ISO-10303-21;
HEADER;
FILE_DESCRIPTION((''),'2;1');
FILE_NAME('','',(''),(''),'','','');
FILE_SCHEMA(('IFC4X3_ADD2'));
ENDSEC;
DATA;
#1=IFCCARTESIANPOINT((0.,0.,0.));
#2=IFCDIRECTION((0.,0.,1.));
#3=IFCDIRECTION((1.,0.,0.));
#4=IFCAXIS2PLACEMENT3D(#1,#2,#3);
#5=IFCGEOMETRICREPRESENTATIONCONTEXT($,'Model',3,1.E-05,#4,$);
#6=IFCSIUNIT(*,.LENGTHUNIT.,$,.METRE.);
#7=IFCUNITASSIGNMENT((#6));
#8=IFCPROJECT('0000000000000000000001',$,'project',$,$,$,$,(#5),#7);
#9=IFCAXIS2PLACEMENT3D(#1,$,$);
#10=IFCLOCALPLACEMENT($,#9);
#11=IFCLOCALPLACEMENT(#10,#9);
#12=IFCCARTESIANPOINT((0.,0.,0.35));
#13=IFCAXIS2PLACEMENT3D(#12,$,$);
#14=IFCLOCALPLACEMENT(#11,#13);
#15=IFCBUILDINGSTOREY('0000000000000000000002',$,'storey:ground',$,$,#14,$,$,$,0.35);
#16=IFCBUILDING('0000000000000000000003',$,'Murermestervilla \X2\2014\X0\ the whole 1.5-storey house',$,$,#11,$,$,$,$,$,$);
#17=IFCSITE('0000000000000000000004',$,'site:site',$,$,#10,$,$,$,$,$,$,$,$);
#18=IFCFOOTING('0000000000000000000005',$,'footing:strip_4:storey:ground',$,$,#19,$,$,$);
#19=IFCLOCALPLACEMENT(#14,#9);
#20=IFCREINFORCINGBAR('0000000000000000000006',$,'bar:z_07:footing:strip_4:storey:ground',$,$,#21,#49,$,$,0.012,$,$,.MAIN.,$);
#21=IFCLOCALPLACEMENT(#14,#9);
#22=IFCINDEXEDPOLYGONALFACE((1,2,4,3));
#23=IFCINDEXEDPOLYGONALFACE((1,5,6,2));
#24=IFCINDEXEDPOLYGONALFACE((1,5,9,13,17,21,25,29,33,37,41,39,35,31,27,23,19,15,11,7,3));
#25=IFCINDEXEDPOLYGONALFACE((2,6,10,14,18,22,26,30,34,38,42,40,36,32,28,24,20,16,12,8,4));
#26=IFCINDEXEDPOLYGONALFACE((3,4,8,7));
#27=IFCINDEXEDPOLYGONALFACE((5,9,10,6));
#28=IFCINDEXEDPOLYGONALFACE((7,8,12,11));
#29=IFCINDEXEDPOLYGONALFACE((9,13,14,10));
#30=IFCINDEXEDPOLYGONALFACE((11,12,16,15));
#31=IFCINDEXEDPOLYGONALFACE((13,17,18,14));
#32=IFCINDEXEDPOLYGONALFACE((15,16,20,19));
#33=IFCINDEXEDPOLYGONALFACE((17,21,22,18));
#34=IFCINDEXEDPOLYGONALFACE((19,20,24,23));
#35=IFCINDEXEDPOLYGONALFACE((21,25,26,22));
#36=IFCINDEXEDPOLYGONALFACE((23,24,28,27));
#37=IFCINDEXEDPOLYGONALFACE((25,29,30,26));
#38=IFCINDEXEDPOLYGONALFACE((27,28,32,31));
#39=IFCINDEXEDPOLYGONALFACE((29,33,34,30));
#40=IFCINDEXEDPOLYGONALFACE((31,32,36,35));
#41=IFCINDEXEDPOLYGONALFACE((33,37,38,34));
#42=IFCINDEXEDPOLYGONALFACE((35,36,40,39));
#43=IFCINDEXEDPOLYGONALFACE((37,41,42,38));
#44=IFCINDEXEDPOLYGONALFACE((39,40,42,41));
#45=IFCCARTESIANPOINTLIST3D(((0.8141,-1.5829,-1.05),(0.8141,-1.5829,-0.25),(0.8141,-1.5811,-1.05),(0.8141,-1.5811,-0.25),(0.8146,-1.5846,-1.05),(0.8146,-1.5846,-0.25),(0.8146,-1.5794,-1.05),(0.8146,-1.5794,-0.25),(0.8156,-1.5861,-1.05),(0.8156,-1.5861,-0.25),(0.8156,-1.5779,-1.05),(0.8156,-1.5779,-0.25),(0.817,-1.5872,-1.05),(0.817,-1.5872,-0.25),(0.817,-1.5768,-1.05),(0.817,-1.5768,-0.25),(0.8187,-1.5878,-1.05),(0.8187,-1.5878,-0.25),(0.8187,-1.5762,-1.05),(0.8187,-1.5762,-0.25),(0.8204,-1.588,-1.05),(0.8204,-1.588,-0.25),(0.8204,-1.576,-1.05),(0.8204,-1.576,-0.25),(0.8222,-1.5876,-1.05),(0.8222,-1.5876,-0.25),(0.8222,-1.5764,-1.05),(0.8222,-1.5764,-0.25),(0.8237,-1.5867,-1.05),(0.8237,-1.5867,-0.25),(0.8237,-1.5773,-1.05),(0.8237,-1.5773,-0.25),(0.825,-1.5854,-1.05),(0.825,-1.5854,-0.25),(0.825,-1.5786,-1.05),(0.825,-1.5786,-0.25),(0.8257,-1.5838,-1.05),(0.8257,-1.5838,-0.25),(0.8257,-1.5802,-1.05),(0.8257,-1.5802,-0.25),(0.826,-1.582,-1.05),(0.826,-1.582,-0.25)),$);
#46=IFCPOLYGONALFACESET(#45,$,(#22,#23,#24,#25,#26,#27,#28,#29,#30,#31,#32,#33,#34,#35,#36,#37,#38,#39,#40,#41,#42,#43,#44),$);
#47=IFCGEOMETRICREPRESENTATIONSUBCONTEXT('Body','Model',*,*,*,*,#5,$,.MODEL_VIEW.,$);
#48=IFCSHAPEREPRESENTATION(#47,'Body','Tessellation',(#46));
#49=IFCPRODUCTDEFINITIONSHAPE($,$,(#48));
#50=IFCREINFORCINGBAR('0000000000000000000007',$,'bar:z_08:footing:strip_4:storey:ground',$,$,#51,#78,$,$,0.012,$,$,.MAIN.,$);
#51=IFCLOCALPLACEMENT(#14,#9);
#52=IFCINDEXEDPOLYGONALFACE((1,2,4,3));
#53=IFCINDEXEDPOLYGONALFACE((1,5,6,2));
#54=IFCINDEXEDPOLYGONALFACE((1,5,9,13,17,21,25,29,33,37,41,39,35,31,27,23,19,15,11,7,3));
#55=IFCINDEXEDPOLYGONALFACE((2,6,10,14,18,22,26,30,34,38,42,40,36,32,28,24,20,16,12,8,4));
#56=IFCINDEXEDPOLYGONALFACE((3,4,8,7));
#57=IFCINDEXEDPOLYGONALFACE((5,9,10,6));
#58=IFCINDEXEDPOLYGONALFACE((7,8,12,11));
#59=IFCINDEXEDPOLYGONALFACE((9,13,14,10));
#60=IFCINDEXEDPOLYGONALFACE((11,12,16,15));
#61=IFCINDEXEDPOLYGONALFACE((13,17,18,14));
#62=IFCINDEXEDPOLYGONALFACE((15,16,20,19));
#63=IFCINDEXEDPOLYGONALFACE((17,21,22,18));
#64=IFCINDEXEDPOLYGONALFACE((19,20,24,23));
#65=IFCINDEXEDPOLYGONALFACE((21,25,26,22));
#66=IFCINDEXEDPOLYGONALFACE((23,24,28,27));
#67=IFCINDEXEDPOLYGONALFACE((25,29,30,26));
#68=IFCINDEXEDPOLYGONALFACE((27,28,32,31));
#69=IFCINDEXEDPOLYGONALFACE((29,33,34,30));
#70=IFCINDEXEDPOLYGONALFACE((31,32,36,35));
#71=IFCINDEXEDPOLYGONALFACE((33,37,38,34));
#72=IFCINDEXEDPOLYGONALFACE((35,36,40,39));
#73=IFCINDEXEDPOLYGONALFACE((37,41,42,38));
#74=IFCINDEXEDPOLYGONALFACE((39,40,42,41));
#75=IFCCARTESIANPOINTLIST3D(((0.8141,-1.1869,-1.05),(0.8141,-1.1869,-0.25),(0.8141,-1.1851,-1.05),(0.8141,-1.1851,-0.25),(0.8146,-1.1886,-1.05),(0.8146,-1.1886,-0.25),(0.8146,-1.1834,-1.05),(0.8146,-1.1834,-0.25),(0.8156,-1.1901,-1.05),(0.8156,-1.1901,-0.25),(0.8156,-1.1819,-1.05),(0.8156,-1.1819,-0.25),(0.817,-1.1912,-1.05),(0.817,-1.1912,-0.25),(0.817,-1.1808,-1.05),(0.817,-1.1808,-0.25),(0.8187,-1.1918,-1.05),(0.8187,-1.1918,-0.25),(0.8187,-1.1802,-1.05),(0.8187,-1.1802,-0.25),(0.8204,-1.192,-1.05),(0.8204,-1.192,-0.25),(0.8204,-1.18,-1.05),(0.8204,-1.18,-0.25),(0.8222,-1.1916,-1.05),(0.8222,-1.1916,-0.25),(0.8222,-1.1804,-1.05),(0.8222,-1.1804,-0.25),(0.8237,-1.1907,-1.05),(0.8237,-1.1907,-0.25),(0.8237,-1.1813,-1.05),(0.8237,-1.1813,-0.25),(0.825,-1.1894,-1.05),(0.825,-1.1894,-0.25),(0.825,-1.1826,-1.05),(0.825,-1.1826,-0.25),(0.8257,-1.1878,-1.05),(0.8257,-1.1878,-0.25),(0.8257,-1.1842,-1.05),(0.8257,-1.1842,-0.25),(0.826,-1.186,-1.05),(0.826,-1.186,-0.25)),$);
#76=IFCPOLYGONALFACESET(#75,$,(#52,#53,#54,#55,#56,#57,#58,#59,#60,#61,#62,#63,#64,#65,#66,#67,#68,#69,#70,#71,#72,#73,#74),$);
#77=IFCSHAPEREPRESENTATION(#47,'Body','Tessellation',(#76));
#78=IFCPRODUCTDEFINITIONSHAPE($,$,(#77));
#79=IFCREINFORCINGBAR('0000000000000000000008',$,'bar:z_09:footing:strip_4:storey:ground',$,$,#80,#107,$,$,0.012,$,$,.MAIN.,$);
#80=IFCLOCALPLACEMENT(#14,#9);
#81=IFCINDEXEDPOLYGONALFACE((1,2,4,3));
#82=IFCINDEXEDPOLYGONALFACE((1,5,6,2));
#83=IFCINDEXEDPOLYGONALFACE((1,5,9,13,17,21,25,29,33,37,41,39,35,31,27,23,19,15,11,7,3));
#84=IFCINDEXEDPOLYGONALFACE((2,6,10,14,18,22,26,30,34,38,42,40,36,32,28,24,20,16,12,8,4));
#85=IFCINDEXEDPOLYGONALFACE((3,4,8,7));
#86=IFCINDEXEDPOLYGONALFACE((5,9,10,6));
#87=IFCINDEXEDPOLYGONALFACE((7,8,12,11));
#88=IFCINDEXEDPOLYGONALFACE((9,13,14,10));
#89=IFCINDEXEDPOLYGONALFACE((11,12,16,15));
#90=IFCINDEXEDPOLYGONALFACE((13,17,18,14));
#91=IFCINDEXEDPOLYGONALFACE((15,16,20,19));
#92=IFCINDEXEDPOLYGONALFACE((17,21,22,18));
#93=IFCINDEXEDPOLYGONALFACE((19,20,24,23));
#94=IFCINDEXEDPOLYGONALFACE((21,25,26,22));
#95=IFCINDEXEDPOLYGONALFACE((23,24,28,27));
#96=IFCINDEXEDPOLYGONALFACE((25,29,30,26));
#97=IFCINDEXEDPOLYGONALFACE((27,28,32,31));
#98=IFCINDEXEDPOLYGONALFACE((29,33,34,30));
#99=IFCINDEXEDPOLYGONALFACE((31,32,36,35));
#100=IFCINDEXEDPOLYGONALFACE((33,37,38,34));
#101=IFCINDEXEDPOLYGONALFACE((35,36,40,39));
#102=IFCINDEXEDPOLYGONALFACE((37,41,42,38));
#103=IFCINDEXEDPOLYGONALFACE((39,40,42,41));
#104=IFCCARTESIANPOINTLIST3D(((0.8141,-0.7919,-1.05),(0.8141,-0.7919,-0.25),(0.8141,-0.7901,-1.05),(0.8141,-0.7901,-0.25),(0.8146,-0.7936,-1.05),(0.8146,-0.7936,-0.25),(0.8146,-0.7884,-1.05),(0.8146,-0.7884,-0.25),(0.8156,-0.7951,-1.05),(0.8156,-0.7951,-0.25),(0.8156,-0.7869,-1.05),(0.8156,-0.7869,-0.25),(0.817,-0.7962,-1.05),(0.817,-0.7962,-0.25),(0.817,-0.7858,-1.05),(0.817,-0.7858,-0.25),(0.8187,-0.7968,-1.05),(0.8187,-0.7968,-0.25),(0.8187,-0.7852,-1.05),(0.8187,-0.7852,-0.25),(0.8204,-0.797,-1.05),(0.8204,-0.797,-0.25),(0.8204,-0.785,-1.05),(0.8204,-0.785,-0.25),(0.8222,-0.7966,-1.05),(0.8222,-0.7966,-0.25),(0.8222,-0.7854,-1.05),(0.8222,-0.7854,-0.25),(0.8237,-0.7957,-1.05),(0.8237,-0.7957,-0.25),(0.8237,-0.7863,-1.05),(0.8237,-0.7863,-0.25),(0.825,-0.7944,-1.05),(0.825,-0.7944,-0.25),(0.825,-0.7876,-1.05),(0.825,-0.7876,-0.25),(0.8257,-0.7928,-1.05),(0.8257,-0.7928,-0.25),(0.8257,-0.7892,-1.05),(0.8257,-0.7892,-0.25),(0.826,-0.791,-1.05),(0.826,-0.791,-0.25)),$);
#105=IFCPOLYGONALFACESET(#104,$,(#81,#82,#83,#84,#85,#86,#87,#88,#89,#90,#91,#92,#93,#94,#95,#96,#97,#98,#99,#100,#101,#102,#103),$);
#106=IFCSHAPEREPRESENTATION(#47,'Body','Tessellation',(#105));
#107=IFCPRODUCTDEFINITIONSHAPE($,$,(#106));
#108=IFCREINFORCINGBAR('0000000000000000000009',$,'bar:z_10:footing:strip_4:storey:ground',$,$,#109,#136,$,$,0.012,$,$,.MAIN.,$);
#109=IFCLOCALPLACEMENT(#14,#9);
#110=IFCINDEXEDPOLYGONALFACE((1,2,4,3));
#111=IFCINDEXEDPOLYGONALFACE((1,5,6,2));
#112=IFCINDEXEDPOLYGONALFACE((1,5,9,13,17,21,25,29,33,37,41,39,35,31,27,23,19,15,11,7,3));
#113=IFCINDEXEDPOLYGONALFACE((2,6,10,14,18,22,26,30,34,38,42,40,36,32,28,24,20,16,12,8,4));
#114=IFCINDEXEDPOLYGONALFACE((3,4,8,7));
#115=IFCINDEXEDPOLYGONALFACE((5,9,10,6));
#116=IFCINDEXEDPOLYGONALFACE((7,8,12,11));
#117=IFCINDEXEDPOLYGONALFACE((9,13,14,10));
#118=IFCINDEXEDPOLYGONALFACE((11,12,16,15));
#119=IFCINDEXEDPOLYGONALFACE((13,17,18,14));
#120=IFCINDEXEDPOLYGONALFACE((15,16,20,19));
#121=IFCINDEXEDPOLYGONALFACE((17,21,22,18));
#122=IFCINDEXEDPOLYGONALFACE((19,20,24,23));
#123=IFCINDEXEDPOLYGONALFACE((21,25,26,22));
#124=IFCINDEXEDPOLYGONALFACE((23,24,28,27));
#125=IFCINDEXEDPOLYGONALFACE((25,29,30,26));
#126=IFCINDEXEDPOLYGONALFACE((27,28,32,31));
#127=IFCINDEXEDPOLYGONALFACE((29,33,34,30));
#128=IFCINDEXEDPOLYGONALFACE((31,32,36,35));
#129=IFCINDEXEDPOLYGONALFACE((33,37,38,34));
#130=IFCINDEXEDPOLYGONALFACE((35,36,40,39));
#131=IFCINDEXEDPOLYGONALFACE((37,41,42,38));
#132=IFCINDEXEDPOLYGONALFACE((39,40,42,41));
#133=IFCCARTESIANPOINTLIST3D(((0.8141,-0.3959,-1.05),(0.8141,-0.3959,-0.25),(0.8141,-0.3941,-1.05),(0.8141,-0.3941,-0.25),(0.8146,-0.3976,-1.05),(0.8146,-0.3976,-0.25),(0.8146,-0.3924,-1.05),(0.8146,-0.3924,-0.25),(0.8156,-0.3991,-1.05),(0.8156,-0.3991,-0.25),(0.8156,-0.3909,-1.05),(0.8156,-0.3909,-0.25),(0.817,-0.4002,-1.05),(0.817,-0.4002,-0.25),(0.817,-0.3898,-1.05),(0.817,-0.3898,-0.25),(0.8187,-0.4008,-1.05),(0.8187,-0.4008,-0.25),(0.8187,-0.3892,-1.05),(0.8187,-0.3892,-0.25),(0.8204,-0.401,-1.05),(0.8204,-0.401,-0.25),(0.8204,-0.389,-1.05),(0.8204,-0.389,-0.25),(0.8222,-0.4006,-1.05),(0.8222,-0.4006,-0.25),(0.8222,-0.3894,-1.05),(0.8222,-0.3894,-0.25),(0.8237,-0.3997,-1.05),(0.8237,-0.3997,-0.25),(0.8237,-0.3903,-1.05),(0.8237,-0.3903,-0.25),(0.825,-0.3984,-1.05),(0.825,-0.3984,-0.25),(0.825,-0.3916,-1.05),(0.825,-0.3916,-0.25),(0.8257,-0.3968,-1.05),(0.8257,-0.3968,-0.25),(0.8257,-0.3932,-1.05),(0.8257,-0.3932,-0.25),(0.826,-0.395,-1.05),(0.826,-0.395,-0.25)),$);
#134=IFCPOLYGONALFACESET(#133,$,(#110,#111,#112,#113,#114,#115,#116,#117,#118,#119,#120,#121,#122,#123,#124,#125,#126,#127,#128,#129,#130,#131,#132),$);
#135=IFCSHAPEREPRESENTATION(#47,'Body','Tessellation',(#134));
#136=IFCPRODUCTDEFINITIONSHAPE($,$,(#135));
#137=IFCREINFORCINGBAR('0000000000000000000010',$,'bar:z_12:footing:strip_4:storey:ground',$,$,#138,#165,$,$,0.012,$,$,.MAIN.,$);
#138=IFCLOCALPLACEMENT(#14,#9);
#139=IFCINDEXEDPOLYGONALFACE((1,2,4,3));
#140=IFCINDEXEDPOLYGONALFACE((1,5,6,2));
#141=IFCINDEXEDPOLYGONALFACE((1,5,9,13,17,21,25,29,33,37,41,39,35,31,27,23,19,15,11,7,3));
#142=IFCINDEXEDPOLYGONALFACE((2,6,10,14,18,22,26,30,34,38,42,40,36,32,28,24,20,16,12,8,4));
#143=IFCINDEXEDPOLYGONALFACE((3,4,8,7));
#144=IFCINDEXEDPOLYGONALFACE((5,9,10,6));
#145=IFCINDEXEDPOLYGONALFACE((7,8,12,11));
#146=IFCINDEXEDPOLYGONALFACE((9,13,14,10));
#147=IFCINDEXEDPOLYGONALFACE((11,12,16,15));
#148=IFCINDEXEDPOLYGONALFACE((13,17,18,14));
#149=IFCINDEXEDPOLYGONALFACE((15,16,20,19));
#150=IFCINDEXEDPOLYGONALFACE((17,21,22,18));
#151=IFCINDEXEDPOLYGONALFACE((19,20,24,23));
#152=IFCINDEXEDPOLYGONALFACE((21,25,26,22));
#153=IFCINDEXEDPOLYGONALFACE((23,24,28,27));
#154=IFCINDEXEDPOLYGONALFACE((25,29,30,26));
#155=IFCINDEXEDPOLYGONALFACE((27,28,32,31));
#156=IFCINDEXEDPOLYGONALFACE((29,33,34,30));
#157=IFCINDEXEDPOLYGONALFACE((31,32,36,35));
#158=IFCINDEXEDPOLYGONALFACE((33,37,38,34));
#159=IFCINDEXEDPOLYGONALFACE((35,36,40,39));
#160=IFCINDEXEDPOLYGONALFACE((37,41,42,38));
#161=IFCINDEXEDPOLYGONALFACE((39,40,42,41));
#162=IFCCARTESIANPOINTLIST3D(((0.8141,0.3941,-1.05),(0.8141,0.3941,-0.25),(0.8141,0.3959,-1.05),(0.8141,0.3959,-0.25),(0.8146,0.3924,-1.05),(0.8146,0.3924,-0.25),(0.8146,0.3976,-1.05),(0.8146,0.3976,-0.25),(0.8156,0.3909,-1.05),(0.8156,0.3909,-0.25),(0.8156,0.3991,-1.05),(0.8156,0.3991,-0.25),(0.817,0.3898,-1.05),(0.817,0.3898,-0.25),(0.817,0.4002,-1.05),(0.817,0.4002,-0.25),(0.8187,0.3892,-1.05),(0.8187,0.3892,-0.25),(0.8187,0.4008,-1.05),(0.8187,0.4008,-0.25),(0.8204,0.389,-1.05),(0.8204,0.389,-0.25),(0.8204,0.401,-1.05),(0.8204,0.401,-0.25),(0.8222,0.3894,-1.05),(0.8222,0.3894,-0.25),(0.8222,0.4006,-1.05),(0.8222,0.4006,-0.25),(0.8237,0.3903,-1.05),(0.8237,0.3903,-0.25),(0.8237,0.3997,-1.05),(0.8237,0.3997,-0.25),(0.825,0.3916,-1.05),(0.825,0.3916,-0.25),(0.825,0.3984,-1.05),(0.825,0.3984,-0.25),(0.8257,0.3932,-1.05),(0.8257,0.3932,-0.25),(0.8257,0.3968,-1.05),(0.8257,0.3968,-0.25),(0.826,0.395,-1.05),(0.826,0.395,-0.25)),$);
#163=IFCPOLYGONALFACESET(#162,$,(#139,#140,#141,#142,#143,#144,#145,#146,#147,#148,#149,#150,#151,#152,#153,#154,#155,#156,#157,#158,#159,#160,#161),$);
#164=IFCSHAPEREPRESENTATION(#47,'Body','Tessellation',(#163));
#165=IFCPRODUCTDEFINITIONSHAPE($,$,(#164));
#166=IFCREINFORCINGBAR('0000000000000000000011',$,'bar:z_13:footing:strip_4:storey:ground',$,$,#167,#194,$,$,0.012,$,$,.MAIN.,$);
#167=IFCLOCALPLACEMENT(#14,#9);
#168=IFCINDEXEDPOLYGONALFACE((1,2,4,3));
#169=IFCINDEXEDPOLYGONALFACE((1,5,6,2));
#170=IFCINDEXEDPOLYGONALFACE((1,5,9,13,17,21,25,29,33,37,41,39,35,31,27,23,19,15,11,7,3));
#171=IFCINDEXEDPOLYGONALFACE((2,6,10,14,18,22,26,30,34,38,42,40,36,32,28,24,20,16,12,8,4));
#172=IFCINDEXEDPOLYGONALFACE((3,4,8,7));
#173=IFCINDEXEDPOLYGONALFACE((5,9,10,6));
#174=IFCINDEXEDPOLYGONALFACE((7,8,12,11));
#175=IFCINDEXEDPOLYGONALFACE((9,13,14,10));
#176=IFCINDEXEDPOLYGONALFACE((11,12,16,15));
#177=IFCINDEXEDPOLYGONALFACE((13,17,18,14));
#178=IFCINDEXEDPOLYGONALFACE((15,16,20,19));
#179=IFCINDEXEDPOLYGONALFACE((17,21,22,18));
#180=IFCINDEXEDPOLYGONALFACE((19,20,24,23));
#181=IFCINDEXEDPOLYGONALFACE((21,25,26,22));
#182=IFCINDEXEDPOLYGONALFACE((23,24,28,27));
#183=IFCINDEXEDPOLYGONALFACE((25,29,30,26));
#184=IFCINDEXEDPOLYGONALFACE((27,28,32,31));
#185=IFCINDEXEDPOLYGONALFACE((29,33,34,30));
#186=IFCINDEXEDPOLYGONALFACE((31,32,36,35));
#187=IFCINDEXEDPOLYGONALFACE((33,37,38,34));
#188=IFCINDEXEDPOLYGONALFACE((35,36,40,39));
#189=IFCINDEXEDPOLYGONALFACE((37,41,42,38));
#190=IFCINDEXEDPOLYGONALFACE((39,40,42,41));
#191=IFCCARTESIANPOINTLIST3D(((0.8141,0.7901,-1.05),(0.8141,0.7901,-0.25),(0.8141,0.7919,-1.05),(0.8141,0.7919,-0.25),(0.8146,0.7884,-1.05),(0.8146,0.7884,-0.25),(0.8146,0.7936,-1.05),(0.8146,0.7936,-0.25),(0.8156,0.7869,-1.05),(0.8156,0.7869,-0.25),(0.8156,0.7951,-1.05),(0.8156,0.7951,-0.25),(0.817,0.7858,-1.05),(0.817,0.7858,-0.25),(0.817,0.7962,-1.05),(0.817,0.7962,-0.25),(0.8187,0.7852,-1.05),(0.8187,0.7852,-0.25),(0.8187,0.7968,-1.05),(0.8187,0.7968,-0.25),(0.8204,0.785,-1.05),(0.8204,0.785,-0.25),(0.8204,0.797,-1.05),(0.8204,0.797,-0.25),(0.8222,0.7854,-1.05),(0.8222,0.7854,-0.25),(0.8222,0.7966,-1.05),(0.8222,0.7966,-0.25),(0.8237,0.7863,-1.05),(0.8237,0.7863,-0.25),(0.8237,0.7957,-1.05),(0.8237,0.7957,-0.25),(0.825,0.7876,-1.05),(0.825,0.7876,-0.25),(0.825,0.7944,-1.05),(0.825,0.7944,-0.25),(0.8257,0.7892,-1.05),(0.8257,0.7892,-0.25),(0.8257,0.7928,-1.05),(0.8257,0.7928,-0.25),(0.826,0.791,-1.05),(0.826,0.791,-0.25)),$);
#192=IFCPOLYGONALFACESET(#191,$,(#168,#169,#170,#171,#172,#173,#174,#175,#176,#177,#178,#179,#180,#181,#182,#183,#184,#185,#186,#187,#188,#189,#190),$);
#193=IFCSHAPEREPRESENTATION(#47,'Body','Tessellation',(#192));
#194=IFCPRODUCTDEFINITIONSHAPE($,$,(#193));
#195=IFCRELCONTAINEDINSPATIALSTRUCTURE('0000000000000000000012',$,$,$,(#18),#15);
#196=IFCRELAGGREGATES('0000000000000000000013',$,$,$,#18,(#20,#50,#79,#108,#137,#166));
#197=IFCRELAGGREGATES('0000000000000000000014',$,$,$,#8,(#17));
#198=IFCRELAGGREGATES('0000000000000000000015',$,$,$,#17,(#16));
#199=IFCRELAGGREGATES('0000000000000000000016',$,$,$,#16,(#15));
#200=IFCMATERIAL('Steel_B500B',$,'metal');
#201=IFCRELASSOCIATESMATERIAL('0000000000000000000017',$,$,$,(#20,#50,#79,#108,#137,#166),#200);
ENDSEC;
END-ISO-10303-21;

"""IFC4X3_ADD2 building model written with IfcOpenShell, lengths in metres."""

from ifc_helpers import new_model, entity, si_unit, frame, origin, origin_with_axes, place, context, subcontext, project, spatial, material, element, aggregate, save


model = new_model("IFC4X3_ADD2")

# Units and contexts
model_context = context("Model", 3, precision=1e-05, world=origin_with_axes())
body_context = subcontext(model_context, "Body", "Model", "MODEL_VIEW")
ifc_project = project(units=[si_unit("LENGTHUNIT", "METRE")], contexts=[model_context])

# Site, building, storey
placement_1 = place(None, origin())
site = spatial("IfcSite", under=ifc_project, at=placement_1, Name="site:site")
building_placement = place(placement_1, origin())
building = spatial("IfcBuilding", under=site, at=building_placement, Name="Murermestervilla — the whole 1.5-storey house")
storey_placement = place(building_placement, frame((0.0, 0.0, 0.35)))
storey = spatial("IfcBuildingStorey", under=building, at=storey_placement, Name="storey:ground", Elevation=0.35)

# Footing, reinforcing bars
placement_2 = place(storey_placement, frame((0.0, 0.0, -0.35)))
ifc_material = material(Name="Steel_B500B", Category="metal")
footing_1 = element("IfcFooting", 1, at=placement_2, inside=storey, Name="footing:strip_4:storey:ground")
reinforcing_bar_1 = element("IfcReinforcingBar", 2, at=placement_1, material=ifc_material, Name="bar:z_07:footing:strip_4:storey:ground", NominalDiameter=0.012, PredefinedType="MAIN", context=body_context, shape_type="AdvancedSweptSolid", body=[
    entity("IfcSweptDiskSolid", entity("IfcPolyline", [entity("IfcCartesianPoint", [0.82, -1.582, -0.7]), entity("IfcCartesianPoint", [0.82, -1.582, 0.1])]), 0.006),
])
reinforcing_bar_2 = element("IfcReinforcingBar", 3, at=placement_1, material=ifc_material, Name="bar:z_08:footing:strip_4:storey:ground", NominalDiameter=0.012, PredefinedType="MAIN", context=body_context, shape_type="AdvancedSweptSolid", body=[
    entity("IfcSweptDiskSolid", entity("IfcPolyline", [entity("IfcCartesianPoint", [0.82, -1.186, -0.7]), entity("IfcCartesianPoint", [0.82, -1.186, 0.1])]), 0.006),
])
reinforcing_bar_3 = element("IfcReinforcingBar", 4, at=placement_1, material=ifc_material, Name="bar:z_09:footing:strip_4:storey:ground", NominalDiameter=0.012, PredefinedType="MAIN", context=body_context, shape_type="AdvancedSweptSolid", body=[
    entity("IfcSweptDiskSolid", entity("IfcPolyline", [entity("IfcCartesianPoint", [0.82, -0.791, -0.7]), entity("IfcCartesianPoint", [0.82, -0.791, 0.1])]), 0.006),
])
reinforcing_bar_4 = element("IfcReinforcingBar", 5, at=placement_1, material=ifc_material, Name="bar:z_10:footing:strip_4:storey:ground", NominalDiameter=0.012, PredefinedType="MAIN", context=body_context, shape_type="AdvancedSweptSolid", body=[
    entity("IfcSweptDiskSolid", entity("IfcPolyline", [entity("IfcCartesianPoint", [0.82, -0.395, -0.7]), entity("IfcCartesianPoint", [0.82, -0.395, 0.1])]), 0.006),
])
reinforcing_bar_5 = element("IfcReinforcingBar", 6, at=placement_1, material=ifc_material, Name="bar:z_12:footing:strip_4:storey:ground", NominalDiameter=0.012, PredefinedType="MAIN", context=body_context, shape_type="AdvancedSweptSolid", body=[
    entity("IfcSweptDiskSolid", entity("IfcPolyline", [entity("IfcCartesianPoint", [0.82, 0.395, -0.7]), entity("IfcCartesianPoint", [0.82, 0.395, 0.1])]), 0.006),
])
reinforcing_bar_6 = element("IfcReinforcingBar", 7, at=placement_1, material=ifc_material, Name="bar:z_13:footing:strip_4:storey:ground", NominalDiameter=0.012, PredefinedType="MAIN", context=body_context, shape_type="AdvancedSweptSolid", body=[
    entity("IfcSweptDiskSolid", entity("IfcPolyline", [entity("IfcCartesianPoint", [0.82, 0.791, -0.7]), entity("IfcCartesianPoint", [0.82, 0.791, 0.1])]), 0.006),
])
aggregate(footing_1, [reinforcing_bar_1, reinforcing_bar_2, reinforcing_bar_3, reinforcing_bar_4, reinforcing_bar_5, reinforcing_bar_6])

save(model, "model.ifc")
